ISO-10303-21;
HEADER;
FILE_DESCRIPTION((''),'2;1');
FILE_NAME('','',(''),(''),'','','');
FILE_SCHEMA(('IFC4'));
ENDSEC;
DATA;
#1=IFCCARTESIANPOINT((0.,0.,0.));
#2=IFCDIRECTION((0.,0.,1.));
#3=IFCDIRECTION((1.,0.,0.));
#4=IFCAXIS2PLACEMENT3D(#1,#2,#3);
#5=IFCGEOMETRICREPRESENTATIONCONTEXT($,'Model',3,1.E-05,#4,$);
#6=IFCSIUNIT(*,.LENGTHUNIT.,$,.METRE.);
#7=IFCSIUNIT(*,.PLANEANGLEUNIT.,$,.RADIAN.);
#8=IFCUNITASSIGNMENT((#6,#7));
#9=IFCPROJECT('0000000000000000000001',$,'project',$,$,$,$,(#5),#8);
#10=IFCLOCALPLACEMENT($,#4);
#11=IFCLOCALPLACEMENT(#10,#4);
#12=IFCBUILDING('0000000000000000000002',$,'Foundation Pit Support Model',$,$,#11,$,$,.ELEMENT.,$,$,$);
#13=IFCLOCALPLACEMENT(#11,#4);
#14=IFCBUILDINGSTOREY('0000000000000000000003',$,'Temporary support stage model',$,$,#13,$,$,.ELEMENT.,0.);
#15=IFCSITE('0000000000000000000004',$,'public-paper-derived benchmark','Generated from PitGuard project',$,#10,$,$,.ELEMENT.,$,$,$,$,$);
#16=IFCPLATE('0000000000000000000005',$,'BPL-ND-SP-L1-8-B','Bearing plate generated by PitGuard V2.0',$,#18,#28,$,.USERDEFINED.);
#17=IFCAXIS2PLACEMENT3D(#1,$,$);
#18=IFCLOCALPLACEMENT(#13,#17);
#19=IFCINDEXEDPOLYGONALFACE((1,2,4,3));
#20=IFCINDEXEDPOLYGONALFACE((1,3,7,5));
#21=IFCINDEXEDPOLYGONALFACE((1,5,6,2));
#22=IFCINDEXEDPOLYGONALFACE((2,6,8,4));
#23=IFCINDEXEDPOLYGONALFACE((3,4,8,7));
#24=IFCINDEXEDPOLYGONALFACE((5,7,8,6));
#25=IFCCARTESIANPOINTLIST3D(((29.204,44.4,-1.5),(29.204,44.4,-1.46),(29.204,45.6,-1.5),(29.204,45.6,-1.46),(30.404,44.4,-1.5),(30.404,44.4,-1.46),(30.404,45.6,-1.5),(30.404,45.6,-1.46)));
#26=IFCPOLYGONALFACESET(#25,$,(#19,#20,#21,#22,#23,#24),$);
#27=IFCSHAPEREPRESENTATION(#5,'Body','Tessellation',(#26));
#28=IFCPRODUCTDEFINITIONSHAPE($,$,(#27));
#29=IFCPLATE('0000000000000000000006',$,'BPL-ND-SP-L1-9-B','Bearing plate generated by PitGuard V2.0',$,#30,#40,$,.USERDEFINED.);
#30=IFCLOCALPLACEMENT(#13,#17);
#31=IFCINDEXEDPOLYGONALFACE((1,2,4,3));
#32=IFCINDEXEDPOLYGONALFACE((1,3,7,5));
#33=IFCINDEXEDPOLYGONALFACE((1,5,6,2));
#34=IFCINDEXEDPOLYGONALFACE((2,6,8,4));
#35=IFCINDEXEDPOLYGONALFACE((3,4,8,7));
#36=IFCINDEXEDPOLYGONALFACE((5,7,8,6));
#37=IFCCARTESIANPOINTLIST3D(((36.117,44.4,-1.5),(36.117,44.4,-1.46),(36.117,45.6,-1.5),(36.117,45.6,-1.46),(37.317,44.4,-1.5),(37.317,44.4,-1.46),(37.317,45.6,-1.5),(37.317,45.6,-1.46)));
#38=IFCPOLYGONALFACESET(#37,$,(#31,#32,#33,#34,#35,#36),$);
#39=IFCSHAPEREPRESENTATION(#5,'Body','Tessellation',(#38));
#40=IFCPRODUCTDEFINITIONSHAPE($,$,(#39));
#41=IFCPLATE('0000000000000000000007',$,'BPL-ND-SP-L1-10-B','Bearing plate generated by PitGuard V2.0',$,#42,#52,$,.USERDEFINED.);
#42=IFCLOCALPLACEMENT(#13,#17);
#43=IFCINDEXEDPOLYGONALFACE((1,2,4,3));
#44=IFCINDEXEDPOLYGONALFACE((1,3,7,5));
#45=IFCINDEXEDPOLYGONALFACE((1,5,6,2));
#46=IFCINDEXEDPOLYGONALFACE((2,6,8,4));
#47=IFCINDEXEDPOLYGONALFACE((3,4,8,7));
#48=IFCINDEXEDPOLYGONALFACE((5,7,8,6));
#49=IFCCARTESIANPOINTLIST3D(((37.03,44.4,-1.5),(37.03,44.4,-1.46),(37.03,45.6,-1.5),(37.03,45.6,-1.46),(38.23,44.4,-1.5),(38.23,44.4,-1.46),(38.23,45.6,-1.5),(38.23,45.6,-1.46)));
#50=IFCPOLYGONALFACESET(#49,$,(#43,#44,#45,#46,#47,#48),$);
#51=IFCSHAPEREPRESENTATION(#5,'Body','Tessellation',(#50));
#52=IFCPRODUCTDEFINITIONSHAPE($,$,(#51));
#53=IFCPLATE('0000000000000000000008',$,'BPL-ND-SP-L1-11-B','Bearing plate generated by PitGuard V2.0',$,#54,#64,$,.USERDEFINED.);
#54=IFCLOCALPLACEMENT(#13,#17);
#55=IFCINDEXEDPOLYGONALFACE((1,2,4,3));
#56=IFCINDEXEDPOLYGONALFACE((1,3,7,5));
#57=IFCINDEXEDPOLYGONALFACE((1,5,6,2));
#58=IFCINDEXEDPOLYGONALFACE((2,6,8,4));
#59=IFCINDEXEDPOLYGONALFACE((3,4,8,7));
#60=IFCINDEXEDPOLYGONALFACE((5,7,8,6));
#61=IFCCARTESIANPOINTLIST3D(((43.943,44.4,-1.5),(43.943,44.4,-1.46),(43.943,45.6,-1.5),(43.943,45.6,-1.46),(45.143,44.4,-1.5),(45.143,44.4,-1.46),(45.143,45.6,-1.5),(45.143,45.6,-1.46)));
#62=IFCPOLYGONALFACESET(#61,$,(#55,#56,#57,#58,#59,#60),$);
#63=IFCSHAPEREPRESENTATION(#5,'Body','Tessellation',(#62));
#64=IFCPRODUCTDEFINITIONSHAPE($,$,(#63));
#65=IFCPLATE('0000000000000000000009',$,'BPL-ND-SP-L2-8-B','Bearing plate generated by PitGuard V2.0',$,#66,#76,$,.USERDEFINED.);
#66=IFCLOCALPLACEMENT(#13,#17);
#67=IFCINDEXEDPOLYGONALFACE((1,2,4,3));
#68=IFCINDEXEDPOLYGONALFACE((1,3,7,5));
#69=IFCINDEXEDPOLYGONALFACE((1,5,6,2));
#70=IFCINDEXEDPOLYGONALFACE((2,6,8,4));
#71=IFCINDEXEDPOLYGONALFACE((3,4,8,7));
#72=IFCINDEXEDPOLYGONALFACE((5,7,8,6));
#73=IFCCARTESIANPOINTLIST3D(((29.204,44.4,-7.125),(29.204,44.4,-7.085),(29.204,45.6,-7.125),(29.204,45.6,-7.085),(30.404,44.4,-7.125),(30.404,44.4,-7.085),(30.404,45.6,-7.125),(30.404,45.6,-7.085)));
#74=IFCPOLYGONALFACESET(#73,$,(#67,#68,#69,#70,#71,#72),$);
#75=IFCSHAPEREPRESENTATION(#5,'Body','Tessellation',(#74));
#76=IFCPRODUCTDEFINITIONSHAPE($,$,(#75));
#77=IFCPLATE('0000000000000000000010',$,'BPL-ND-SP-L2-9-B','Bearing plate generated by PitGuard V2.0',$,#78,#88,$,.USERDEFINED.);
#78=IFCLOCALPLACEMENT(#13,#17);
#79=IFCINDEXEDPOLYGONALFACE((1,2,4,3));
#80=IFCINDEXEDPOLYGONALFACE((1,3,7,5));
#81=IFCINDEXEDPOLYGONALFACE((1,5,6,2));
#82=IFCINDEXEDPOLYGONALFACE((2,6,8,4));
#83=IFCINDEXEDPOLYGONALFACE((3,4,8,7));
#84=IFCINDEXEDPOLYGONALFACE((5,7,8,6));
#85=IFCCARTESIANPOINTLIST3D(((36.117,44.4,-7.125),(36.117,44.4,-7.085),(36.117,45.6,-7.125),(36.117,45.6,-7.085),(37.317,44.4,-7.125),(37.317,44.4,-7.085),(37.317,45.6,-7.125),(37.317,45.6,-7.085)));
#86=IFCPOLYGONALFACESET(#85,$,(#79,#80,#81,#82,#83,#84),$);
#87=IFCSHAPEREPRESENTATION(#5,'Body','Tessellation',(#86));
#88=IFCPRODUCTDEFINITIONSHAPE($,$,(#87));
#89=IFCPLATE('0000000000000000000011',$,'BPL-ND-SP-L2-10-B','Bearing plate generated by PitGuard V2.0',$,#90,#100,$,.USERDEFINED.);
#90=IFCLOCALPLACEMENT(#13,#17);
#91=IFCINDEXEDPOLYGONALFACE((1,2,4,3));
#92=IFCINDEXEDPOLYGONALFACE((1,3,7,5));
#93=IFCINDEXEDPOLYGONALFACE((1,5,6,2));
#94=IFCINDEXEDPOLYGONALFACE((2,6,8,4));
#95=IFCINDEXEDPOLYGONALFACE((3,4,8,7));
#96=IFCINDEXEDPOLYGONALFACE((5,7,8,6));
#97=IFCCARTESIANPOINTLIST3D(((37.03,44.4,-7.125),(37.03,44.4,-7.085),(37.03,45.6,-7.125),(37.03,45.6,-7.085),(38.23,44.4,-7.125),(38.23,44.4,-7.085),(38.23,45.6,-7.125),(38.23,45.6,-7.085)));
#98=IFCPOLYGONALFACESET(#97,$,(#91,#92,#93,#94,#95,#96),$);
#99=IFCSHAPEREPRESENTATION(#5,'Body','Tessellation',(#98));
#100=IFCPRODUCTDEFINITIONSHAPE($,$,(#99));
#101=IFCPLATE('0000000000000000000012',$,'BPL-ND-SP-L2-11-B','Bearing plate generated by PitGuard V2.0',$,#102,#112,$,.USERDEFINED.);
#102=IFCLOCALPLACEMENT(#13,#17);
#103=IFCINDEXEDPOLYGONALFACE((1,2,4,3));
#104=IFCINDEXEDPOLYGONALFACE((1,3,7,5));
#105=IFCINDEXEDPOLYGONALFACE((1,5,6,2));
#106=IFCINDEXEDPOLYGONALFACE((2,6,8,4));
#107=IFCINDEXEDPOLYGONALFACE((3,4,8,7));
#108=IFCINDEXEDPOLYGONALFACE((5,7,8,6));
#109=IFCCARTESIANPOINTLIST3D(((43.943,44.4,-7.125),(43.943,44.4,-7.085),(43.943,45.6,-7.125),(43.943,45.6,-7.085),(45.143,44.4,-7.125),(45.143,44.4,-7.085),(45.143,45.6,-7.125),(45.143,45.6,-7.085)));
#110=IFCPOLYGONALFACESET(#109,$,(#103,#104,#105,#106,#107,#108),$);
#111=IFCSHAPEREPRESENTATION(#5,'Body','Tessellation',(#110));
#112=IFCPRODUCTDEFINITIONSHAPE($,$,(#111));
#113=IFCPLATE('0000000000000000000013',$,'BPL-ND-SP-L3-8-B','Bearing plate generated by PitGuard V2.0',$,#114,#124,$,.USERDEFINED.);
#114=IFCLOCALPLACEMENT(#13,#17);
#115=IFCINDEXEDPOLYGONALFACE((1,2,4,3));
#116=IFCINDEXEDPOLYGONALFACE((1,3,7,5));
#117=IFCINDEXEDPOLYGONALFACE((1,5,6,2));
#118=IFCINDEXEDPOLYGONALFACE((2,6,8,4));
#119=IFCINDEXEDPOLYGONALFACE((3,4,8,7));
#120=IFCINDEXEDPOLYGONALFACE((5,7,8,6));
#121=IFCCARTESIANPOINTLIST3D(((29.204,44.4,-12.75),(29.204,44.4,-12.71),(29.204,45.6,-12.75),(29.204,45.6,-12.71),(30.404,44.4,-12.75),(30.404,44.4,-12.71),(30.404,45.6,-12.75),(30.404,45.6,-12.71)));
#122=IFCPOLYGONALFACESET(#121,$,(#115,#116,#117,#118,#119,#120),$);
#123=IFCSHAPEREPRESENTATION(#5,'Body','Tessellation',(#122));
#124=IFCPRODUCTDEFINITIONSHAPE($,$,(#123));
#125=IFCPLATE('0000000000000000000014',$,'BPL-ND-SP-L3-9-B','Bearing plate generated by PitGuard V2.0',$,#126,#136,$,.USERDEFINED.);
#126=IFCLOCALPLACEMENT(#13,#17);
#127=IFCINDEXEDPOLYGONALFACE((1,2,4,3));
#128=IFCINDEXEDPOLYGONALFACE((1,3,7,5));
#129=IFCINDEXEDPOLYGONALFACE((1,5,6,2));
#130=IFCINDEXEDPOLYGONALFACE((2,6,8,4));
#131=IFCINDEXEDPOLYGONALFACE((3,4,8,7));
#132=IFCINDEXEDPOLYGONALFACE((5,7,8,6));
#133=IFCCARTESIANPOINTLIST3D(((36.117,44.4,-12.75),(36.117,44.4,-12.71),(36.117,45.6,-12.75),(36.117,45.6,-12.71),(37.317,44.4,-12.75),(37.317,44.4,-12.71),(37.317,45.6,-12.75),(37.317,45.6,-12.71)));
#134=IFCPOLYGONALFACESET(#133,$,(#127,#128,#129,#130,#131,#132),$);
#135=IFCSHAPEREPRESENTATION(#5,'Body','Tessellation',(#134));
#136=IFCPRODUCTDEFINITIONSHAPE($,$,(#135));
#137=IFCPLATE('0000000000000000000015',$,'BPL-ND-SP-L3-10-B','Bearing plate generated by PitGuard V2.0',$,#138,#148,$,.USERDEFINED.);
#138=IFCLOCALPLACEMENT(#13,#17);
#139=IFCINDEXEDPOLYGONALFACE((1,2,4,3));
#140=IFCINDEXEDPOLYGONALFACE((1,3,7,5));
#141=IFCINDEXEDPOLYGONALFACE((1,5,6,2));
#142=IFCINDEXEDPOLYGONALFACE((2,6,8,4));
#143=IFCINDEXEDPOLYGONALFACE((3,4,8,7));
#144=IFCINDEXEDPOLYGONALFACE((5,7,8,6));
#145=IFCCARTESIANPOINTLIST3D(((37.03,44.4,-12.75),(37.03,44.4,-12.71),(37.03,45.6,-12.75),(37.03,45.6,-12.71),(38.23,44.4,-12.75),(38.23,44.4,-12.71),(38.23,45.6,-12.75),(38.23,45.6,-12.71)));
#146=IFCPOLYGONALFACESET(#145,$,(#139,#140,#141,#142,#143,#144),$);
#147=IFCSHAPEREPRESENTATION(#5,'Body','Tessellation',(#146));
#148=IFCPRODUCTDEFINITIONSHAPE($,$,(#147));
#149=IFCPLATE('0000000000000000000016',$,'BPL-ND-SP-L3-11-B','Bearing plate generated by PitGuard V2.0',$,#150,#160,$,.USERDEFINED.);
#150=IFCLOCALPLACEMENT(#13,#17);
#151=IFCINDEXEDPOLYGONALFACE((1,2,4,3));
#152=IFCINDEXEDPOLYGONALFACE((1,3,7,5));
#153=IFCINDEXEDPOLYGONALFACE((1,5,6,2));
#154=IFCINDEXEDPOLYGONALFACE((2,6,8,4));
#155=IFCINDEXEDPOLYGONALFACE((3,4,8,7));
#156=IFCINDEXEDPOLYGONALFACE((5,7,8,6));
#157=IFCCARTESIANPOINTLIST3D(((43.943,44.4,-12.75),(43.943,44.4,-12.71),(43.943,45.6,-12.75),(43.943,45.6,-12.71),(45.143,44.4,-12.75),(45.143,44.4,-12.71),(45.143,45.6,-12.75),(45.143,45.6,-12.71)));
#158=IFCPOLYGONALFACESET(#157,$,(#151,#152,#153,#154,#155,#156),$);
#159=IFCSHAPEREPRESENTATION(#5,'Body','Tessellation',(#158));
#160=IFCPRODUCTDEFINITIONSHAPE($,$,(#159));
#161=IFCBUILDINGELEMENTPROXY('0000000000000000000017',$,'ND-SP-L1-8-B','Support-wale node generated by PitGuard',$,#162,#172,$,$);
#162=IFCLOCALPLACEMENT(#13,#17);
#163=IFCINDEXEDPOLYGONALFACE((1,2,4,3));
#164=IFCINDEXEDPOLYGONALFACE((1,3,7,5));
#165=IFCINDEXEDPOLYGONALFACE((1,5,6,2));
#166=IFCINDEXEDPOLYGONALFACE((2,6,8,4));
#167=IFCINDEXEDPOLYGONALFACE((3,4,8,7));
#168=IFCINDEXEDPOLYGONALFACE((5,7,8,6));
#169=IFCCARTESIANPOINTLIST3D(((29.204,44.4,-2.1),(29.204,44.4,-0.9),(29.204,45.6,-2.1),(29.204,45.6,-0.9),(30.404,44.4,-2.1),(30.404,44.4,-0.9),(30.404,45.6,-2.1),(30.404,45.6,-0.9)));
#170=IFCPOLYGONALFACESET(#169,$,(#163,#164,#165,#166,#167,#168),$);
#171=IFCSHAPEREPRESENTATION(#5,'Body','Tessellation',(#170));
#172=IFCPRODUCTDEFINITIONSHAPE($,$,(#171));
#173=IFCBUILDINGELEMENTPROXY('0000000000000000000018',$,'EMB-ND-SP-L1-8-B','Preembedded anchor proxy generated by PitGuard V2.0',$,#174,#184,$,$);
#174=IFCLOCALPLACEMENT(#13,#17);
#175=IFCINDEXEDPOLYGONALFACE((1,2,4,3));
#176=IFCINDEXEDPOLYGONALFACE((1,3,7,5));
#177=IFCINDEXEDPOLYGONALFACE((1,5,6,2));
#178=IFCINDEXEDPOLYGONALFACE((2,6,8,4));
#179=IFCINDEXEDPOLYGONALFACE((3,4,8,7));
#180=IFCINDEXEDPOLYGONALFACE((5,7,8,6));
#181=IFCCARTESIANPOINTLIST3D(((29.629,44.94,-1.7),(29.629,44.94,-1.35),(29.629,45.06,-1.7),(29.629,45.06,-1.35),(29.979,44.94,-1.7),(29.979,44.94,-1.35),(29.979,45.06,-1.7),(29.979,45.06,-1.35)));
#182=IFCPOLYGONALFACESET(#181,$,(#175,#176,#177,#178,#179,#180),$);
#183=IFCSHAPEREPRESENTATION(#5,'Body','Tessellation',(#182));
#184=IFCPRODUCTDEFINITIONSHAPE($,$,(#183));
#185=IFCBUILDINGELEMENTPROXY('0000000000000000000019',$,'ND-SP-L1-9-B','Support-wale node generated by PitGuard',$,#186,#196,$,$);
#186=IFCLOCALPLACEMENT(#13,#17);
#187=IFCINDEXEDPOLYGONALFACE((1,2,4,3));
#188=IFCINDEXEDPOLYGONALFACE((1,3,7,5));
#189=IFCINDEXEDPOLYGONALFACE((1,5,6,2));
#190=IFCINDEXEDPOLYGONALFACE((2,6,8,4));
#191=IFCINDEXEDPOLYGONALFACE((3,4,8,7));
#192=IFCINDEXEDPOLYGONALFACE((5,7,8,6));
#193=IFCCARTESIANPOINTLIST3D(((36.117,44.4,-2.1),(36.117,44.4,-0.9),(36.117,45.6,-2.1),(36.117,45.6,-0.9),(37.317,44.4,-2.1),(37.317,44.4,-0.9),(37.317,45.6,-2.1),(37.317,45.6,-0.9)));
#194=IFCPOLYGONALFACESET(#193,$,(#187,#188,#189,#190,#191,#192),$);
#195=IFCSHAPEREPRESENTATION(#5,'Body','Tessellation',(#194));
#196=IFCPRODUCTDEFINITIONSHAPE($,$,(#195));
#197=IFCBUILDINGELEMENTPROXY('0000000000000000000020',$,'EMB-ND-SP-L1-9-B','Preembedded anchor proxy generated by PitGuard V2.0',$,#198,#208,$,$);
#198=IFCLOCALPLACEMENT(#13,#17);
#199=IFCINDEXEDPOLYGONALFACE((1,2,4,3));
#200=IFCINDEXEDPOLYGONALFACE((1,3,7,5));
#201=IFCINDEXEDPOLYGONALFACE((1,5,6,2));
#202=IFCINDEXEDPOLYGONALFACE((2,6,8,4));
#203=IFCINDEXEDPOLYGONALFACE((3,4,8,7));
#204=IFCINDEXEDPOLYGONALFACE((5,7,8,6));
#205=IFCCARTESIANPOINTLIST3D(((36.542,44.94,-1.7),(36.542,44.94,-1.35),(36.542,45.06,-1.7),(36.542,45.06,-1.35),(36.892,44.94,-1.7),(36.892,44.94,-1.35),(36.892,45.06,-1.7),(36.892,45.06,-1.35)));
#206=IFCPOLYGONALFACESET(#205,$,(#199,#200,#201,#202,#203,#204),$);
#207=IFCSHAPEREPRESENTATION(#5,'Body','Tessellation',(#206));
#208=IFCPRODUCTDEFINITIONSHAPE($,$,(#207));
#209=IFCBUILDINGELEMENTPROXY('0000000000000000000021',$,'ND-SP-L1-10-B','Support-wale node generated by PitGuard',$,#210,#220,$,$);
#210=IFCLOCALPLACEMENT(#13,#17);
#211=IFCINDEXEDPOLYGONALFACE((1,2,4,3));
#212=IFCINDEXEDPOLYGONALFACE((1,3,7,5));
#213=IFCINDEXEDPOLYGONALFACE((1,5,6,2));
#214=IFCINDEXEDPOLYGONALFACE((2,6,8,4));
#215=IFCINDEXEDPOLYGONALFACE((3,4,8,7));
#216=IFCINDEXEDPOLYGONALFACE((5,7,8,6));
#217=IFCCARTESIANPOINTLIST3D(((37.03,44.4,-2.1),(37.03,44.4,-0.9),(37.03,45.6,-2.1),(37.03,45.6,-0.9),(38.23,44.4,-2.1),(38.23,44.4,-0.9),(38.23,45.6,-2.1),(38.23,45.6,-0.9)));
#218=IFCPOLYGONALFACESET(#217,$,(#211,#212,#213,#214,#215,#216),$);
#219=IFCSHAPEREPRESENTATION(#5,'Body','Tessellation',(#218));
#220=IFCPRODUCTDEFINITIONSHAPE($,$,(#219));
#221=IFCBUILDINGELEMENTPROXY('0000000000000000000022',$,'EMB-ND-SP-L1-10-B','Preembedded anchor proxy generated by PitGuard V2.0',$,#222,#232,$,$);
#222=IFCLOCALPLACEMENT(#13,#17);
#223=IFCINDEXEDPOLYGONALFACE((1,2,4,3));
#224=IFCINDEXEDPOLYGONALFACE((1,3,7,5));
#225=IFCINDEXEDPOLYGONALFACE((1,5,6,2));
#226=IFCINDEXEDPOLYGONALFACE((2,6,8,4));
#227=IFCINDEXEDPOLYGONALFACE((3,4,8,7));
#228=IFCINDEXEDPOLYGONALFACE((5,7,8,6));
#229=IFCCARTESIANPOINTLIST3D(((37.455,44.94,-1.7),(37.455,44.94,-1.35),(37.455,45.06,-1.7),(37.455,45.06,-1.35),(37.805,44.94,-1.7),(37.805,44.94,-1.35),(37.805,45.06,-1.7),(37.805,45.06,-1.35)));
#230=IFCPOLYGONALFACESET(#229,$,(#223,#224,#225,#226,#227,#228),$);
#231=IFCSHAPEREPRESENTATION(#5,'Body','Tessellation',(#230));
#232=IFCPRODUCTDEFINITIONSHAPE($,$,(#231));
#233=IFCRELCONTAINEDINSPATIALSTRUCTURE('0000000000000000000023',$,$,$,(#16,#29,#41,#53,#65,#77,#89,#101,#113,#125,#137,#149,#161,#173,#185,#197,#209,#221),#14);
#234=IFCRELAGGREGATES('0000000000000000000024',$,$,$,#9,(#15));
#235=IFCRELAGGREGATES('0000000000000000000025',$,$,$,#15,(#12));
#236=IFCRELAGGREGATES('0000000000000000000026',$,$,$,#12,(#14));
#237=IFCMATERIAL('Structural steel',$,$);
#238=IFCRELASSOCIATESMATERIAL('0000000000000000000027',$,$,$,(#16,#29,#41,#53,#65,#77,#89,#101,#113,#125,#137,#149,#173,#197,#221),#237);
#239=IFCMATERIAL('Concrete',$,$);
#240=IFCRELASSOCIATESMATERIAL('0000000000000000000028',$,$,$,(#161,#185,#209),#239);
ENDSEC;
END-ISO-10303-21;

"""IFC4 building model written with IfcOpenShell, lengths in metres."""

from ifc_helpers import new_model, si_unit, frame, origin_with_axes, origin_2d, place, context, project, spatial, rectangle, extrude, material, element, save


model = new_model("IFC4")

# Units and contexts
model_context = context("Model", 3, precision=1e-05, world=origin_with_axes())
ifc_project = project(units=[si_unit("LENGTHUNIT", "METRE"), si_unit("PLANEANGLEUNIT", "RADIAN")], contexts=[model_context])

# Site, building, storey
site_placement = place(None, origin_with_axes())
site = spatial("IfcSite", under=ifc_project, at=site_placement, Name="public-paper-derived benchmark", Description="Generated from PitGuard project", CompositionType="ELEMENT")
building_placement = place(site_placement, origin_with_axes())
building = spatial("IfcBuilding", under=site, at=building_placement, Name="Foundation Pit Support Model", CompositionType="ELEMENT")
storey_placement = place(building_placement, origin_with_axes())
storey = spatial("IfcBuildingStorey", under=building, at=storey_placement, Name="Temporary support stage model", CompositionType="ELEMENT", Elevation=0.0)

# Plates
ifc_material_1 = material(Name="Structural steel")
for number, where, z_axis, x_axis, name in (
    (1, (29.804, 45.0, -1.5), (0.0, 0.0, 1.0), (1.0, 0.0, 0.0), "BPL-ND-SP-L1-8-B"),
    (2, (36.717, 45.0, -1.5), (0.0, 0.0, 1.0), (1.0, 0.0, 0.0), "BPL-ND-SP-L1-9-B"),
    (3, (37.63, 45.0, -1.5), (0.0, 0.0, 1.0), (1.0, 0.0, 0.0), "BPL-ND-SP-L1-10-B"),
    (4, (44.543, 45.0, -1.5), (0.0, 0.0, 1.0), (1.0, 0.0, 0.0), "BPL-ND-SP-L1-11-B"),
    (5, (29.804, 45.0, -7.125), (0.0, 0.0, 1.0), (1.0, 0.0, 0.0), "BPL-ND-SP-L2-8-B"),
    (6, (36.717, 45.0, -7.125), (0.0, 0.0, 1.0), (1.0, 0.0, 0.0), "BPL-ND-SP-L2-9-B"),
    (7, (37.63, 45.0, -7.125), (0.0, 0.0, 1.0), (1.0, 0.0, 0.0), "BPL-ND-SP-L2-10-B"),
    (8, (44.543, 45.0, -7.125), (0.0, 0.0, 1.0), (1.0, 0.0, 0.0), "BPL-ND-SP-L2-11-B"),
    (9, (29.804, 45.0, -12.75), (0.0, 0.0, 1.0), (1.0, 0.0, 0.0), "BPL-ND-SP-L3-8-B"),
    (10, (36.717, 45.0, -12.75), (0.0, 0.0, 1.0), (1.0, 0.0, 0.0), "BPL-ND-SP-L3-9-B"),
    (11, (37.63, 45.0, -12.75), (0.0, 0.0, 1.0), (1.0, 0.0, 0.0), "BPL-ND-SP-L3-10-B"),
    (12, (44.543, 45.0, -12.75), (0.0, 0.0, 1.0), (1.0, 0.0, 0.0), "BPL-ND-SP-L3-11-B"),
):
    element("IfcPlate", number, at=place(storey_placement, frame(where, z_axis=z_axis, x_axis=x_axis)), inside=storey, material=ifc_material_1, Name=name, Description="Bearing plate generated by PitGuard V2.0", PredefinedType="USERDEFINED", context=model_context, shape_type="SweptSolid", body=[
        extrude(rectangle(XDim=1.2, YDim=1.2, at=origin_2d()), origin_with_axes(), (0.0, 0.0, 1.0), 0.04),
    ])

# Building element proxies
ifc_material_2 = material(Name="Concrete")
proxy_1_placement = place(storey_placement, frame((29.804, 45.0, -2.1), z_axis=(0.0, 0.0, 1.0), x_axis=(1.0, 0.0, 0.0)))
element("IfcBuildingElementProxy", 13, at=proxy_1_placement, inside=storey, material=ifc_material_2, Name="ND-SP-L1-8-B", Description="Support-wale node generated by PitGuard", context=model_context, shape_type="SweptSolid", body=[
    extrude(rectangle(XDim=1.2, YDim=1.2, at=origin_2d()), origin_with_axes(), (0.0, 0.0, 1.0), 1.2),
])
proxy_2_placement = place(storey_placement, frame((29.804, 45.0, -1.7), z_axis=(0.0, 0.0, 1.0), x_axis=(1.0, 0.0, 0.0)))
element("IfcBuildingElementProxy", 14, at=proxy_2_placement, inside=storey, material=ifc_material_1, Name="EMB-ND-SP-L1-8-B", Description="Preembedded anchor proxy generated by PitGuard V2.0", context=model_context, shape_type="SweptSolid", body=[
    extrude(rectangle(XDim=0.35, YDim=0.12, at=origin_2d()), origin_with_axes(), (0.0, 0.0, 1.0), 0.35),
])
proxy_3_placement = place(storey_placement, frame((36.717, 45.0, -2.1), z_axis=(0.0, 0.0, 1.0), x_axis=(1.0, 0.0, 0.0)))
element("IfcBuildingElementProxy", 15, at=proxy_3_placement, inside=storey, material=ifc_material_2, Name="ND-SP-L1-9-B", Description="Support-wale node generated by PitGuard", context=model_context, shape_type="SweptSolid", body=[
    extrude(rectangle(XDim=1.2, YDim=1.2, at=origin_2d()), origin_with_axes(), (0.0, 0.0, 1.0), 1.2),
])
proxy_4_placement = place(storey_placement, frame((36.717, 45.0, -1.7), z_axis=(0.0, 0.0, 1.0), x_axis=(1.0, 0.0, 0.0)))
element("IfcBuildingElementProxy", 16, at=proxy_4_placement, inside=storey, material=ifc_material_1, Name="EMB-ND-SP-L1-9-B", Description="Preembedded anchor proxy generated by PitGuard V2.0", context=model_context, shape_type="SweptSolid", body=[
    extrude(rectangle(XDim=0.35, YDim=0.12, at=origin_2d()), origin_with_axes(), (0.0, 0.0, 1.0), 0.35),
])
proxy_5_placement = place(storey_placement, frame((37.63, 45.0, -2.1), z_axis=(0.0, 0.0, 1.0), x_axis=(1.0, 0.0, 0.0)))
element("IfcBuildingElementProxy", 17, at=proxy_5_placement, inside=storey, material=ifc_material_2, Name="ND-SP-L1-10-B", Description="Support-wale node generated by PitGuard", context=model_context, shape_type="SweptSolid", body=[
    extrude(rectangle(XDim=1.2, YDim=1.2, at=origin_2d()), origin_with_axes(), (0.0, 0.0, 1.0), 1.2),
])
proxy_6_placement = place(storey_placement, frame((37.63, 45.0, -1.7), z_axis=(0.0, 0.0, 1.0), x_axis=(1.0, 0.0, 0.0)))
element("IfcBuildingElementProxy", 18, at=proxy_6_placement, inside=storey, material=ifc_material_1, Name="EMB-ND-SP-L1-10-B", Description="Preembedded anchor proxy generated by PitGuard V2.0", context=model_context, shape_type="SweptSolid", body=[
    extrude(rectangle(XDim=0.35, YDim=0.12, at=origin_2d()), origin_with_axes(), (0.0, 0.0, 1.0), 0.35),
])

save(model, "model.ifc")
